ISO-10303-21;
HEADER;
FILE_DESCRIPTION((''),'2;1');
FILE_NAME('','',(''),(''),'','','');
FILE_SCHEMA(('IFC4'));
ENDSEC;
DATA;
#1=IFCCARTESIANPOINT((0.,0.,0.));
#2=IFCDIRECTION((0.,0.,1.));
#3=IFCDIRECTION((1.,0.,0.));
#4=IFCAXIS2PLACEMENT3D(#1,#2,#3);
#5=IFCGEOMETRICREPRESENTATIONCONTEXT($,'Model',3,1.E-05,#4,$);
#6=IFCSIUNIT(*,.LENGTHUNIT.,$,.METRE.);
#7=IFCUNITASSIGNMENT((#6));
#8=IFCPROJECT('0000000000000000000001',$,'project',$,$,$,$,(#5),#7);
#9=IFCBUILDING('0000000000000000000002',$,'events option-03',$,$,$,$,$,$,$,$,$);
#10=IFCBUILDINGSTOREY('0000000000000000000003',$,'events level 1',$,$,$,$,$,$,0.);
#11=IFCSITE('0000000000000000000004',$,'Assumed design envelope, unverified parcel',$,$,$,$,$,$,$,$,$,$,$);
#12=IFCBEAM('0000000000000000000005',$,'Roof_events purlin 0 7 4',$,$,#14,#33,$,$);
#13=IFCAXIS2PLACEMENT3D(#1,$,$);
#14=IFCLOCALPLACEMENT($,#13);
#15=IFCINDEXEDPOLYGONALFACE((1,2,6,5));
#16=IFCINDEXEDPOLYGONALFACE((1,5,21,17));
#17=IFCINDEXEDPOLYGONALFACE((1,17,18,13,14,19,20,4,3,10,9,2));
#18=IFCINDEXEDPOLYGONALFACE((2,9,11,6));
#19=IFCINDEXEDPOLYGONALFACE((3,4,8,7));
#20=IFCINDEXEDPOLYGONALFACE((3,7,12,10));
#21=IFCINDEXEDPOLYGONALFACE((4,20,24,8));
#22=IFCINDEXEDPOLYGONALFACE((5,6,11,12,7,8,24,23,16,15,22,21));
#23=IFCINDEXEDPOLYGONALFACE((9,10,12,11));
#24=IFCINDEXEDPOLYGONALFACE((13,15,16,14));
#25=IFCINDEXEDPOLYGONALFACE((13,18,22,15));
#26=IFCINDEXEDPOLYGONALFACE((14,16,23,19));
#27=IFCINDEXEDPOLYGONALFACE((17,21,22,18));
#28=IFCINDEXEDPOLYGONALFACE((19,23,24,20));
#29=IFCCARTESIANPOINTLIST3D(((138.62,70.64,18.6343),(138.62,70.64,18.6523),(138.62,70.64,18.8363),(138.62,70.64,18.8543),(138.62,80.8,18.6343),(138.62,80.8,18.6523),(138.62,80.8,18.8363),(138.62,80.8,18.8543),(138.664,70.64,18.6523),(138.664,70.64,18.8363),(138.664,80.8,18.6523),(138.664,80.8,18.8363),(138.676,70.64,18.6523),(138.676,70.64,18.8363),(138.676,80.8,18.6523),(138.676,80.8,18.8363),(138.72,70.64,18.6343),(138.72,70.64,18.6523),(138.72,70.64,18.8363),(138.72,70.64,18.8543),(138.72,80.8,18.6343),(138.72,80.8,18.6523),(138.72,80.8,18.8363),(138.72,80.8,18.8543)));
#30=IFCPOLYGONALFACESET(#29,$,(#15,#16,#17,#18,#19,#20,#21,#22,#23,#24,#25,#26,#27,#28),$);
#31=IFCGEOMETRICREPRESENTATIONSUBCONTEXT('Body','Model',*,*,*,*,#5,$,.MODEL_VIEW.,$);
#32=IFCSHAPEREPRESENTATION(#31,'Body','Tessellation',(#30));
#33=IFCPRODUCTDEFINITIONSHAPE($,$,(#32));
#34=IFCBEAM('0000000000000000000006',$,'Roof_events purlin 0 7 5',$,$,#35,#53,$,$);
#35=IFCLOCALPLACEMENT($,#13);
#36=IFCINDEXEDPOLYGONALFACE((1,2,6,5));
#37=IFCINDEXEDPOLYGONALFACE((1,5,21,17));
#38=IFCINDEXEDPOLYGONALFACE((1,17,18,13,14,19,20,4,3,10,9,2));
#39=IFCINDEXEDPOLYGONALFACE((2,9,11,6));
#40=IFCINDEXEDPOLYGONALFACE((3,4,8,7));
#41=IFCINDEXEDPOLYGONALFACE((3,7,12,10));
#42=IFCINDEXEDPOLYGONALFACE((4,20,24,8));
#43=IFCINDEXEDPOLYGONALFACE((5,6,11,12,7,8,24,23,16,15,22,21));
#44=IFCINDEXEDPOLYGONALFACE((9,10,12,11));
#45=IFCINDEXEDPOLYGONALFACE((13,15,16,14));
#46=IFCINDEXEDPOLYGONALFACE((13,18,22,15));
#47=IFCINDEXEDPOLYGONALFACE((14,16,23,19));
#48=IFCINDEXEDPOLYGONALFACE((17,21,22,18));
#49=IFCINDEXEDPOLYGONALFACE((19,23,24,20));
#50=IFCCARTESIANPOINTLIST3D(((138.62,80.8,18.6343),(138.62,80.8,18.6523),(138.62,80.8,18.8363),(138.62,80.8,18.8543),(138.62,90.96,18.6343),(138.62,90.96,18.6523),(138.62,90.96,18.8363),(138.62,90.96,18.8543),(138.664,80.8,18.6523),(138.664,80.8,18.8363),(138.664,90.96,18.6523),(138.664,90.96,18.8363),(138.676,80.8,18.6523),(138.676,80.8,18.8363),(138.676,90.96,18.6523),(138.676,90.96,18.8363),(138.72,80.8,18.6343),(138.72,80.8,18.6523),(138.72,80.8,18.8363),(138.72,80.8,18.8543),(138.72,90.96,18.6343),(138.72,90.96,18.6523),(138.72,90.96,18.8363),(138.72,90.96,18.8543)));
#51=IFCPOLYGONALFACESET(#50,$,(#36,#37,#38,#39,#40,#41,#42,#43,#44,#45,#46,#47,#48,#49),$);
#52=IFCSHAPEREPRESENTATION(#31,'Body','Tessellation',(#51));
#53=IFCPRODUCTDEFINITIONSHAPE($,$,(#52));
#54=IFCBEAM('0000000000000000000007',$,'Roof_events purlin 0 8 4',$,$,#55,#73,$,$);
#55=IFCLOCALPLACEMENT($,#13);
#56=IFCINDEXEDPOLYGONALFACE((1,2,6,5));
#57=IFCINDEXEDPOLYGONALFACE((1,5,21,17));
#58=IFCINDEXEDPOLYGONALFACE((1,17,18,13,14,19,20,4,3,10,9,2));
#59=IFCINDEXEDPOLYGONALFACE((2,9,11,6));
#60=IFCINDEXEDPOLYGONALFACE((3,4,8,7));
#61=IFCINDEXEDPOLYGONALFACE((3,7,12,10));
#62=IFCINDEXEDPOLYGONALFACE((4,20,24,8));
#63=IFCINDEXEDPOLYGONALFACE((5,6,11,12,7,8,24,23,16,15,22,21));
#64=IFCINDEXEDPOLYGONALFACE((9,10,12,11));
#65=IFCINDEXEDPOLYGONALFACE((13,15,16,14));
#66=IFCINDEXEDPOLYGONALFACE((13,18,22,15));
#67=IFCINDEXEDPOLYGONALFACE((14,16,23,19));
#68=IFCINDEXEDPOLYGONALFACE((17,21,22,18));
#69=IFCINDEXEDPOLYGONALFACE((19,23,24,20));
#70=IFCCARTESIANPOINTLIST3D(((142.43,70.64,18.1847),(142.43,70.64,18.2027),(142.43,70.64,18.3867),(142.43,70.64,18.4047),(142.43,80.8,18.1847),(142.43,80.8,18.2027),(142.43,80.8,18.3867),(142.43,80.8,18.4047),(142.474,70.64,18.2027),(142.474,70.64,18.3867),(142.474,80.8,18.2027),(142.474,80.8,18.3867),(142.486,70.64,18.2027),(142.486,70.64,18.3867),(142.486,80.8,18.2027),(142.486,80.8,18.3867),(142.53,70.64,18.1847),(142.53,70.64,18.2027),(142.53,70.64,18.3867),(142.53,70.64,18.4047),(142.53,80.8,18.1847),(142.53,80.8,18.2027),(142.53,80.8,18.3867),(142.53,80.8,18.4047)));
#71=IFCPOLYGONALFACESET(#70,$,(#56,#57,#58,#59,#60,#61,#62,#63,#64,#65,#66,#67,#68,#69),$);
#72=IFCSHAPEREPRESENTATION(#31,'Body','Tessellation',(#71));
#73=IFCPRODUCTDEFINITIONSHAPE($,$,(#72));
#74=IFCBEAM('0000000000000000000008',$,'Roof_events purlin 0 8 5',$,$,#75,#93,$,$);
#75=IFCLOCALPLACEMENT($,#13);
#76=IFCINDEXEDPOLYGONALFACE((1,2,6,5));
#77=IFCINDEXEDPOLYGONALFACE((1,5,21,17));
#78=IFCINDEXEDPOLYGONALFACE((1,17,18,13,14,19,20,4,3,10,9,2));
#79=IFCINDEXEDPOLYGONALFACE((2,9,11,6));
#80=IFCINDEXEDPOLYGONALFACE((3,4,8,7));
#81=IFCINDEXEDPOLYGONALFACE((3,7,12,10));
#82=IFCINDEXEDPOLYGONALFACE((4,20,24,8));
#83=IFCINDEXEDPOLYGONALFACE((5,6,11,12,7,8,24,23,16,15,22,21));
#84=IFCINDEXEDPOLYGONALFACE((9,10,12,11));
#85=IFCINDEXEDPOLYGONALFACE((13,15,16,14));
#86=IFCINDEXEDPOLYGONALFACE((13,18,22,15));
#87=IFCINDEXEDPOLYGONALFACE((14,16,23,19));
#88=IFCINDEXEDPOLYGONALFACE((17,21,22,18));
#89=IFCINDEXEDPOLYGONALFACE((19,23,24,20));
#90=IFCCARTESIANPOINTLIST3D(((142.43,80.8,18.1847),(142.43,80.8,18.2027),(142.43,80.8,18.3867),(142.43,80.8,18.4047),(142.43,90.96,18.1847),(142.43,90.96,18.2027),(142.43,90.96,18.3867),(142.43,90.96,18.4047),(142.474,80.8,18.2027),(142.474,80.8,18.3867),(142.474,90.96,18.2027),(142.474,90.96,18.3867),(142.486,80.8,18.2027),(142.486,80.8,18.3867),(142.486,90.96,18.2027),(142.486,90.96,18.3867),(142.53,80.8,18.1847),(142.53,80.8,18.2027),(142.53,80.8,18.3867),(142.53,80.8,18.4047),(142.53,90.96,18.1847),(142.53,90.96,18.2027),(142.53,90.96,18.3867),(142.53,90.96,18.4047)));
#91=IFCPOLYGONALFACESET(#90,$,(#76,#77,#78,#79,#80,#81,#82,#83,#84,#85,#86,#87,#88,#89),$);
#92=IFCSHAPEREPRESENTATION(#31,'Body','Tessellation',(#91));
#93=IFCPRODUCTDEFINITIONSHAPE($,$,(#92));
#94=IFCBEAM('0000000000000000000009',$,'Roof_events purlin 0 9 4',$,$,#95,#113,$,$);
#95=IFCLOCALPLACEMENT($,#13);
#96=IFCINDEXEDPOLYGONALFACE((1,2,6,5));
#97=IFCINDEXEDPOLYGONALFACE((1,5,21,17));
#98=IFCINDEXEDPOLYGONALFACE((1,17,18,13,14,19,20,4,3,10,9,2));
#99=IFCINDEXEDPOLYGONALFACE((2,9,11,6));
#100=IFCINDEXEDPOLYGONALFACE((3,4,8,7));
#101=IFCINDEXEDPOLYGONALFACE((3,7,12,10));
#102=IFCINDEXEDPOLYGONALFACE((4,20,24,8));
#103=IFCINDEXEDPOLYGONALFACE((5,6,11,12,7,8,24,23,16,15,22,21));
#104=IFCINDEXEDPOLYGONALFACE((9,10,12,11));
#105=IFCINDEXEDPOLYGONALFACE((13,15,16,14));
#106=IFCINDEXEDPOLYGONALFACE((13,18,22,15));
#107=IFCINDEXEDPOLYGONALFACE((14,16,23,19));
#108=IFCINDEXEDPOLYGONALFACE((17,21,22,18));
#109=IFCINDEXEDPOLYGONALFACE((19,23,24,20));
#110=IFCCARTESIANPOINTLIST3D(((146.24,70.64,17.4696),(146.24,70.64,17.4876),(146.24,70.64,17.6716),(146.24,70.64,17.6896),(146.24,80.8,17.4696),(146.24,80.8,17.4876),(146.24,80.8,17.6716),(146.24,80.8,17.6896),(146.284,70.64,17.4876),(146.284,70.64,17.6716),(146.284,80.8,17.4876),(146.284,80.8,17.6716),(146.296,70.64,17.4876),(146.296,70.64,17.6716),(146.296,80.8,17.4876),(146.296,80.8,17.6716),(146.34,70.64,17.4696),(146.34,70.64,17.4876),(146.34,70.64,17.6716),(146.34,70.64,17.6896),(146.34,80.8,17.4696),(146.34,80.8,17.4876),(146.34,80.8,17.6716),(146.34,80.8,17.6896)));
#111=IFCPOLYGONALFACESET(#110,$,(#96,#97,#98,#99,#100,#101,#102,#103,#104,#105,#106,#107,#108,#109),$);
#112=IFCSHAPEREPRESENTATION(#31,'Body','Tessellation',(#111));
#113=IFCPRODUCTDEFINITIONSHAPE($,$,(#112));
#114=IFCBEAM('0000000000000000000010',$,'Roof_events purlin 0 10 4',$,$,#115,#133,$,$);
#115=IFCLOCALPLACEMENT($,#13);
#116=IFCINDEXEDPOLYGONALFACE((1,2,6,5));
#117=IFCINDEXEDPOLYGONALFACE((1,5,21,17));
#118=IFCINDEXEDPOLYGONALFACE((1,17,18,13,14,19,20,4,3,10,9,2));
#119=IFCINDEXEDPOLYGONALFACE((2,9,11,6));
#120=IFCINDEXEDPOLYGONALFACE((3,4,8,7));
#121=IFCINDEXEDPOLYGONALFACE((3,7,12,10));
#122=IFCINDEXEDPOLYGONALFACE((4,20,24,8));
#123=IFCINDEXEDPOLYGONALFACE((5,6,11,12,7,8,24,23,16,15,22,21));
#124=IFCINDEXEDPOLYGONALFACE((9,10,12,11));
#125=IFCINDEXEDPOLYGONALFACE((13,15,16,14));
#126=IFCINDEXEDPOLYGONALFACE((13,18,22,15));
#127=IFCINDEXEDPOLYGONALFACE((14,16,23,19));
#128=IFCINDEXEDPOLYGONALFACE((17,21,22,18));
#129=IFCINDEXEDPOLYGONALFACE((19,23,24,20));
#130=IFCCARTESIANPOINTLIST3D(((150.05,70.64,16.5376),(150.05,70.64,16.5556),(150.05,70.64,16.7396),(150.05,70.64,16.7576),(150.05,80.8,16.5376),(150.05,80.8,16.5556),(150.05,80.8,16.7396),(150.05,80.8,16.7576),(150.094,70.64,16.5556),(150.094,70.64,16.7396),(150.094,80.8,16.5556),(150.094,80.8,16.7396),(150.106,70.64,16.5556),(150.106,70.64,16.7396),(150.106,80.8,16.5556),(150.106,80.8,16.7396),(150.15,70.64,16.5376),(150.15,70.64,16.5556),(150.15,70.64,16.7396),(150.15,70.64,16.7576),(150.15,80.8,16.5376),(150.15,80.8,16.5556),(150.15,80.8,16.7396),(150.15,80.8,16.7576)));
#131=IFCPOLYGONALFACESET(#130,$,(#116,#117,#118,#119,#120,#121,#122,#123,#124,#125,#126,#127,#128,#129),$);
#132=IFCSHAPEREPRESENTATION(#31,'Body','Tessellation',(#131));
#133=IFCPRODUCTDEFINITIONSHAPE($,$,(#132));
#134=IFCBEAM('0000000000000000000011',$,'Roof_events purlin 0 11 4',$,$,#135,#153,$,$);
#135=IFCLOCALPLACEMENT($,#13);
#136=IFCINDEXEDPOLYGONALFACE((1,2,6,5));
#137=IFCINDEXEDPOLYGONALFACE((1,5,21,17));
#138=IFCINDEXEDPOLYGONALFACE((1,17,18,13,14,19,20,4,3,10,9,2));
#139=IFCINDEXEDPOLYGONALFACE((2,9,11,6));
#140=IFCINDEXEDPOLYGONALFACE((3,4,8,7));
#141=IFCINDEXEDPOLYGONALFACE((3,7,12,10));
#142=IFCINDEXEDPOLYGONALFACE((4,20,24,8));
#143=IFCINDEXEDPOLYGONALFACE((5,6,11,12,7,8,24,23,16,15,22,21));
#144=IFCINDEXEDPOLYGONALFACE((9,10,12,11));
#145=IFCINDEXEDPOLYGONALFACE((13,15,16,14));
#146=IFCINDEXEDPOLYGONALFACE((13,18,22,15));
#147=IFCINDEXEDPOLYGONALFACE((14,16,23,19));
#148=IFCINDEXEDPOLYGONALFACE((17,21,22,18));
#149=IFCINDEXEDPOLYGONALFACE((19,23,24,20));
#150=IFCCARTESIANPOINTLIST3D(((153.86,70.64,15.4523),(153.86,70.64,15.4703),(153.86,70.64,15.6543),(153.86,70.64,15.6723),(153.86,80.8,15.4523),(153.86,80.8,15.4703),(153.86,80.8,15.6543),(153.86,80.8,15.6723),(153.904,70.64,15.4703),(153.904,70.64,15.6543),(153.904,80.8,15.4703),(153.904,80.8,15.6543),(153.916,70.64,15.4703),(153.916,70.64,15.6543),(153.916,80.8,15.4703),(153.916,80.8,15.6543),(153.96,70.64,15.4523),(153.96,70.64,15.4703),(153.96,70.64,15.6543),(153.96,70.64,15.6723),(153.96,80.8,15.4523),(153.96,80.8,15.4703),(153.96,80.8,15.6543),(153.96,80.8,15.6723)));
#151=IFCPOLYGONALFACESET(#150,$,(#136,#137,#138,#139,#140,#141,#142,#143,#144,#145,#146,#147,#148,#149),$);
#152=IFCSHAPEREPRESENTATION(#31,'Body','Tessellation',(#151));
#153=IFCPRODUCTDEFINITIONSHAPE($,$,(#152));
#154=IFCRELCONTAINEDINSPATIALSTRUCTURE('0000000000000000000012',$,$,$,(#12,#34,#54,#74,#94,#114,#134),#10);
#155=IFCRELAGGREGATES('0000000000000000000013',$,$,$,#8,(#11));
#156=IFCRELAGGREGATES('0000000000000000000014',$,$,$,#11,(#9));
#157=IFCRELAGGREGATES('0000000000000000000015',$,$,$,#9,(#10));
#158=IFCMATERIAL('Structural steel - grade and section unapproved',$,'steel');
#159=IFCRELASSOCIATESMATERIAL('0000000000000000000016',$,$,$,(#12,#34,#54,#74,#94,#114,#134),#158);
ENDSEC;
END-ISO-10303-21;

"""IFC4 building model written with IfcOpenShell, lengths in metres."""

from ifc_helpers import new_model, si_unit, frame, origin_with_axes, place, context, subcontext, project, spatial, i_section, extrude, material, element, save


model = new_model("IFC4")

# Units and contexts
model_context = context("Model", 3, precision=1e-05, world=origin_with_axes())
body_context = subcontext(model_context, "Body", "Model", "MODEL_VIEW")
ifc_project = project(units=[si_unit("LENGTHUNIT", "METRE")], contexts=[model_context])

# Site, building, storey
site = spatial("IfcSite", under=ifc_project, Name="Assumed design envelope, unverified parcel")
building = spatial("IfcBuilding", under=site, Name="events option-03")
storey = spatial("IfcBuildingStorey", under=building, Name="events level 1", Elevation=0.0)

# Beams
ifc_material = material(Name="Structural steel - grade and section unapproved", Category="steel")
beam_1_placement = place(None, frame((138.67, 70.64, 18.7443), z_axis=(0.0, 1.0, 0.0), x_axis=(-1.0, 0.0, 0.0)))
element("IfcBeam", 1, at=beam_1_placement, inside=storey, material=ifc_material, Name="Roof_events purlin 0 7 4", context=body_context, shape_type="SweptSolid", body=[
    extrude(i_section(OverallWidth=0.1, OverallDepth=0.22, WebThickness=0.012, FlangeThickness=0.018, FilletRadius=0.0), origin_with_axes(), (0.0, 0.0, 1.0), 10.16),
])
beam_2_placement = place(None, frame((138.67, 80.8, 18.7443), z_axis=(0.0, 1.0, 0.0), x_axis=(-1.0, 0.0, 0.0)))
element("IfcBeam", 2, at=beam_2_placement, inside=storey, material=ifc_material, Name="Roof_events purlin 0 7 5", context=body_context, shape_type="SweptSolid", body=[
    extrude(i_section(OverallWidth=0.1, OverallDepth=0.22, WebThickness=0.012, FlangeThickness=0.018, FilletRadius=0.0), origin_with_axes(), (0.0, 0.0, 1.0), 10.16),
])
beam_3_placement = place(None, frame((142.48, 70.64, 18.2947), z_axis=(0.0, 1.0, 0.0), x_axis=(-1.0, 0.0, 0.0)))
element("IfcBeam", 3, at=beam_3_placement, inside=storey, material=ifc_material, Name="Roof_events purlin 0 8 4", context=body_context, shape_type="SweptSolid", body=[
    extrude(i_section(OverallWidth=0.1, OverallDepth=0.22, WebThickness=0.012, FlangeThickness=0.018, FilletRadius=0.0), origin_with_axes(), (0.0, 0.0, 1.0), 10.16),
])
beam_4_placement = place(None, frame((142.48, 80.8, 18.2947), z_axis=(0.0, 1.0, 0.0), x_axis=(-1.0, 0.0, 0.0)))
element("IfcBeam", 4, at=beam_4_placement, inside=storey, material=ifc_material, Name="Roof_events purlin 0 8 5", context=body_context, shape_type="SweptSolid", body=[
    extrude(i_section(OverallWidth=0.1, OverallDepth=0.22, WebThickness=0.012, FlangeThickness=0.018, FilletRadius=0.0), origin_with_axes(), (0.0, 0.0, 1.0), 10.16),
])
for number, where, z_axis, x_axis, name in (
    (5, (146.29, 70.64, 17.5796), (0.0, 1.0, 0.0), (-1.0, 0.0, 0.0), "Roof_events purlin 0 9 4"),
    (6, (150.1, 70.64, 16.6476), (0.0, 1.0, 0.0), (-1.0, 0.0, 0.0), "Roof_events purlin 0 10 4"),
    (7, (153.91, 70.64, 15.5623), (0.0, 1.0, 0.0), (-1.0, 0.0, 0.0), "Roof_events purlin 0 11 4"),
):
    element("IfcBeam", number, at=place(None, frame(where, z_axis=z_axis, x_axis=x_axis)), inside=storey, material=ifc_material, Name=name, context=body_context, shape_type="SweptSolid", body=[
        extrude(i_section(OverallWidth=0.1, OverallDepth=0.22, WebThickness=0.012, FlangeThickness=0.018, FilletRadius=0.0), origin_with_axes(), (0.0, 0.0, 1.0), 10.16),
    ])

save(model, "model.ifc")
